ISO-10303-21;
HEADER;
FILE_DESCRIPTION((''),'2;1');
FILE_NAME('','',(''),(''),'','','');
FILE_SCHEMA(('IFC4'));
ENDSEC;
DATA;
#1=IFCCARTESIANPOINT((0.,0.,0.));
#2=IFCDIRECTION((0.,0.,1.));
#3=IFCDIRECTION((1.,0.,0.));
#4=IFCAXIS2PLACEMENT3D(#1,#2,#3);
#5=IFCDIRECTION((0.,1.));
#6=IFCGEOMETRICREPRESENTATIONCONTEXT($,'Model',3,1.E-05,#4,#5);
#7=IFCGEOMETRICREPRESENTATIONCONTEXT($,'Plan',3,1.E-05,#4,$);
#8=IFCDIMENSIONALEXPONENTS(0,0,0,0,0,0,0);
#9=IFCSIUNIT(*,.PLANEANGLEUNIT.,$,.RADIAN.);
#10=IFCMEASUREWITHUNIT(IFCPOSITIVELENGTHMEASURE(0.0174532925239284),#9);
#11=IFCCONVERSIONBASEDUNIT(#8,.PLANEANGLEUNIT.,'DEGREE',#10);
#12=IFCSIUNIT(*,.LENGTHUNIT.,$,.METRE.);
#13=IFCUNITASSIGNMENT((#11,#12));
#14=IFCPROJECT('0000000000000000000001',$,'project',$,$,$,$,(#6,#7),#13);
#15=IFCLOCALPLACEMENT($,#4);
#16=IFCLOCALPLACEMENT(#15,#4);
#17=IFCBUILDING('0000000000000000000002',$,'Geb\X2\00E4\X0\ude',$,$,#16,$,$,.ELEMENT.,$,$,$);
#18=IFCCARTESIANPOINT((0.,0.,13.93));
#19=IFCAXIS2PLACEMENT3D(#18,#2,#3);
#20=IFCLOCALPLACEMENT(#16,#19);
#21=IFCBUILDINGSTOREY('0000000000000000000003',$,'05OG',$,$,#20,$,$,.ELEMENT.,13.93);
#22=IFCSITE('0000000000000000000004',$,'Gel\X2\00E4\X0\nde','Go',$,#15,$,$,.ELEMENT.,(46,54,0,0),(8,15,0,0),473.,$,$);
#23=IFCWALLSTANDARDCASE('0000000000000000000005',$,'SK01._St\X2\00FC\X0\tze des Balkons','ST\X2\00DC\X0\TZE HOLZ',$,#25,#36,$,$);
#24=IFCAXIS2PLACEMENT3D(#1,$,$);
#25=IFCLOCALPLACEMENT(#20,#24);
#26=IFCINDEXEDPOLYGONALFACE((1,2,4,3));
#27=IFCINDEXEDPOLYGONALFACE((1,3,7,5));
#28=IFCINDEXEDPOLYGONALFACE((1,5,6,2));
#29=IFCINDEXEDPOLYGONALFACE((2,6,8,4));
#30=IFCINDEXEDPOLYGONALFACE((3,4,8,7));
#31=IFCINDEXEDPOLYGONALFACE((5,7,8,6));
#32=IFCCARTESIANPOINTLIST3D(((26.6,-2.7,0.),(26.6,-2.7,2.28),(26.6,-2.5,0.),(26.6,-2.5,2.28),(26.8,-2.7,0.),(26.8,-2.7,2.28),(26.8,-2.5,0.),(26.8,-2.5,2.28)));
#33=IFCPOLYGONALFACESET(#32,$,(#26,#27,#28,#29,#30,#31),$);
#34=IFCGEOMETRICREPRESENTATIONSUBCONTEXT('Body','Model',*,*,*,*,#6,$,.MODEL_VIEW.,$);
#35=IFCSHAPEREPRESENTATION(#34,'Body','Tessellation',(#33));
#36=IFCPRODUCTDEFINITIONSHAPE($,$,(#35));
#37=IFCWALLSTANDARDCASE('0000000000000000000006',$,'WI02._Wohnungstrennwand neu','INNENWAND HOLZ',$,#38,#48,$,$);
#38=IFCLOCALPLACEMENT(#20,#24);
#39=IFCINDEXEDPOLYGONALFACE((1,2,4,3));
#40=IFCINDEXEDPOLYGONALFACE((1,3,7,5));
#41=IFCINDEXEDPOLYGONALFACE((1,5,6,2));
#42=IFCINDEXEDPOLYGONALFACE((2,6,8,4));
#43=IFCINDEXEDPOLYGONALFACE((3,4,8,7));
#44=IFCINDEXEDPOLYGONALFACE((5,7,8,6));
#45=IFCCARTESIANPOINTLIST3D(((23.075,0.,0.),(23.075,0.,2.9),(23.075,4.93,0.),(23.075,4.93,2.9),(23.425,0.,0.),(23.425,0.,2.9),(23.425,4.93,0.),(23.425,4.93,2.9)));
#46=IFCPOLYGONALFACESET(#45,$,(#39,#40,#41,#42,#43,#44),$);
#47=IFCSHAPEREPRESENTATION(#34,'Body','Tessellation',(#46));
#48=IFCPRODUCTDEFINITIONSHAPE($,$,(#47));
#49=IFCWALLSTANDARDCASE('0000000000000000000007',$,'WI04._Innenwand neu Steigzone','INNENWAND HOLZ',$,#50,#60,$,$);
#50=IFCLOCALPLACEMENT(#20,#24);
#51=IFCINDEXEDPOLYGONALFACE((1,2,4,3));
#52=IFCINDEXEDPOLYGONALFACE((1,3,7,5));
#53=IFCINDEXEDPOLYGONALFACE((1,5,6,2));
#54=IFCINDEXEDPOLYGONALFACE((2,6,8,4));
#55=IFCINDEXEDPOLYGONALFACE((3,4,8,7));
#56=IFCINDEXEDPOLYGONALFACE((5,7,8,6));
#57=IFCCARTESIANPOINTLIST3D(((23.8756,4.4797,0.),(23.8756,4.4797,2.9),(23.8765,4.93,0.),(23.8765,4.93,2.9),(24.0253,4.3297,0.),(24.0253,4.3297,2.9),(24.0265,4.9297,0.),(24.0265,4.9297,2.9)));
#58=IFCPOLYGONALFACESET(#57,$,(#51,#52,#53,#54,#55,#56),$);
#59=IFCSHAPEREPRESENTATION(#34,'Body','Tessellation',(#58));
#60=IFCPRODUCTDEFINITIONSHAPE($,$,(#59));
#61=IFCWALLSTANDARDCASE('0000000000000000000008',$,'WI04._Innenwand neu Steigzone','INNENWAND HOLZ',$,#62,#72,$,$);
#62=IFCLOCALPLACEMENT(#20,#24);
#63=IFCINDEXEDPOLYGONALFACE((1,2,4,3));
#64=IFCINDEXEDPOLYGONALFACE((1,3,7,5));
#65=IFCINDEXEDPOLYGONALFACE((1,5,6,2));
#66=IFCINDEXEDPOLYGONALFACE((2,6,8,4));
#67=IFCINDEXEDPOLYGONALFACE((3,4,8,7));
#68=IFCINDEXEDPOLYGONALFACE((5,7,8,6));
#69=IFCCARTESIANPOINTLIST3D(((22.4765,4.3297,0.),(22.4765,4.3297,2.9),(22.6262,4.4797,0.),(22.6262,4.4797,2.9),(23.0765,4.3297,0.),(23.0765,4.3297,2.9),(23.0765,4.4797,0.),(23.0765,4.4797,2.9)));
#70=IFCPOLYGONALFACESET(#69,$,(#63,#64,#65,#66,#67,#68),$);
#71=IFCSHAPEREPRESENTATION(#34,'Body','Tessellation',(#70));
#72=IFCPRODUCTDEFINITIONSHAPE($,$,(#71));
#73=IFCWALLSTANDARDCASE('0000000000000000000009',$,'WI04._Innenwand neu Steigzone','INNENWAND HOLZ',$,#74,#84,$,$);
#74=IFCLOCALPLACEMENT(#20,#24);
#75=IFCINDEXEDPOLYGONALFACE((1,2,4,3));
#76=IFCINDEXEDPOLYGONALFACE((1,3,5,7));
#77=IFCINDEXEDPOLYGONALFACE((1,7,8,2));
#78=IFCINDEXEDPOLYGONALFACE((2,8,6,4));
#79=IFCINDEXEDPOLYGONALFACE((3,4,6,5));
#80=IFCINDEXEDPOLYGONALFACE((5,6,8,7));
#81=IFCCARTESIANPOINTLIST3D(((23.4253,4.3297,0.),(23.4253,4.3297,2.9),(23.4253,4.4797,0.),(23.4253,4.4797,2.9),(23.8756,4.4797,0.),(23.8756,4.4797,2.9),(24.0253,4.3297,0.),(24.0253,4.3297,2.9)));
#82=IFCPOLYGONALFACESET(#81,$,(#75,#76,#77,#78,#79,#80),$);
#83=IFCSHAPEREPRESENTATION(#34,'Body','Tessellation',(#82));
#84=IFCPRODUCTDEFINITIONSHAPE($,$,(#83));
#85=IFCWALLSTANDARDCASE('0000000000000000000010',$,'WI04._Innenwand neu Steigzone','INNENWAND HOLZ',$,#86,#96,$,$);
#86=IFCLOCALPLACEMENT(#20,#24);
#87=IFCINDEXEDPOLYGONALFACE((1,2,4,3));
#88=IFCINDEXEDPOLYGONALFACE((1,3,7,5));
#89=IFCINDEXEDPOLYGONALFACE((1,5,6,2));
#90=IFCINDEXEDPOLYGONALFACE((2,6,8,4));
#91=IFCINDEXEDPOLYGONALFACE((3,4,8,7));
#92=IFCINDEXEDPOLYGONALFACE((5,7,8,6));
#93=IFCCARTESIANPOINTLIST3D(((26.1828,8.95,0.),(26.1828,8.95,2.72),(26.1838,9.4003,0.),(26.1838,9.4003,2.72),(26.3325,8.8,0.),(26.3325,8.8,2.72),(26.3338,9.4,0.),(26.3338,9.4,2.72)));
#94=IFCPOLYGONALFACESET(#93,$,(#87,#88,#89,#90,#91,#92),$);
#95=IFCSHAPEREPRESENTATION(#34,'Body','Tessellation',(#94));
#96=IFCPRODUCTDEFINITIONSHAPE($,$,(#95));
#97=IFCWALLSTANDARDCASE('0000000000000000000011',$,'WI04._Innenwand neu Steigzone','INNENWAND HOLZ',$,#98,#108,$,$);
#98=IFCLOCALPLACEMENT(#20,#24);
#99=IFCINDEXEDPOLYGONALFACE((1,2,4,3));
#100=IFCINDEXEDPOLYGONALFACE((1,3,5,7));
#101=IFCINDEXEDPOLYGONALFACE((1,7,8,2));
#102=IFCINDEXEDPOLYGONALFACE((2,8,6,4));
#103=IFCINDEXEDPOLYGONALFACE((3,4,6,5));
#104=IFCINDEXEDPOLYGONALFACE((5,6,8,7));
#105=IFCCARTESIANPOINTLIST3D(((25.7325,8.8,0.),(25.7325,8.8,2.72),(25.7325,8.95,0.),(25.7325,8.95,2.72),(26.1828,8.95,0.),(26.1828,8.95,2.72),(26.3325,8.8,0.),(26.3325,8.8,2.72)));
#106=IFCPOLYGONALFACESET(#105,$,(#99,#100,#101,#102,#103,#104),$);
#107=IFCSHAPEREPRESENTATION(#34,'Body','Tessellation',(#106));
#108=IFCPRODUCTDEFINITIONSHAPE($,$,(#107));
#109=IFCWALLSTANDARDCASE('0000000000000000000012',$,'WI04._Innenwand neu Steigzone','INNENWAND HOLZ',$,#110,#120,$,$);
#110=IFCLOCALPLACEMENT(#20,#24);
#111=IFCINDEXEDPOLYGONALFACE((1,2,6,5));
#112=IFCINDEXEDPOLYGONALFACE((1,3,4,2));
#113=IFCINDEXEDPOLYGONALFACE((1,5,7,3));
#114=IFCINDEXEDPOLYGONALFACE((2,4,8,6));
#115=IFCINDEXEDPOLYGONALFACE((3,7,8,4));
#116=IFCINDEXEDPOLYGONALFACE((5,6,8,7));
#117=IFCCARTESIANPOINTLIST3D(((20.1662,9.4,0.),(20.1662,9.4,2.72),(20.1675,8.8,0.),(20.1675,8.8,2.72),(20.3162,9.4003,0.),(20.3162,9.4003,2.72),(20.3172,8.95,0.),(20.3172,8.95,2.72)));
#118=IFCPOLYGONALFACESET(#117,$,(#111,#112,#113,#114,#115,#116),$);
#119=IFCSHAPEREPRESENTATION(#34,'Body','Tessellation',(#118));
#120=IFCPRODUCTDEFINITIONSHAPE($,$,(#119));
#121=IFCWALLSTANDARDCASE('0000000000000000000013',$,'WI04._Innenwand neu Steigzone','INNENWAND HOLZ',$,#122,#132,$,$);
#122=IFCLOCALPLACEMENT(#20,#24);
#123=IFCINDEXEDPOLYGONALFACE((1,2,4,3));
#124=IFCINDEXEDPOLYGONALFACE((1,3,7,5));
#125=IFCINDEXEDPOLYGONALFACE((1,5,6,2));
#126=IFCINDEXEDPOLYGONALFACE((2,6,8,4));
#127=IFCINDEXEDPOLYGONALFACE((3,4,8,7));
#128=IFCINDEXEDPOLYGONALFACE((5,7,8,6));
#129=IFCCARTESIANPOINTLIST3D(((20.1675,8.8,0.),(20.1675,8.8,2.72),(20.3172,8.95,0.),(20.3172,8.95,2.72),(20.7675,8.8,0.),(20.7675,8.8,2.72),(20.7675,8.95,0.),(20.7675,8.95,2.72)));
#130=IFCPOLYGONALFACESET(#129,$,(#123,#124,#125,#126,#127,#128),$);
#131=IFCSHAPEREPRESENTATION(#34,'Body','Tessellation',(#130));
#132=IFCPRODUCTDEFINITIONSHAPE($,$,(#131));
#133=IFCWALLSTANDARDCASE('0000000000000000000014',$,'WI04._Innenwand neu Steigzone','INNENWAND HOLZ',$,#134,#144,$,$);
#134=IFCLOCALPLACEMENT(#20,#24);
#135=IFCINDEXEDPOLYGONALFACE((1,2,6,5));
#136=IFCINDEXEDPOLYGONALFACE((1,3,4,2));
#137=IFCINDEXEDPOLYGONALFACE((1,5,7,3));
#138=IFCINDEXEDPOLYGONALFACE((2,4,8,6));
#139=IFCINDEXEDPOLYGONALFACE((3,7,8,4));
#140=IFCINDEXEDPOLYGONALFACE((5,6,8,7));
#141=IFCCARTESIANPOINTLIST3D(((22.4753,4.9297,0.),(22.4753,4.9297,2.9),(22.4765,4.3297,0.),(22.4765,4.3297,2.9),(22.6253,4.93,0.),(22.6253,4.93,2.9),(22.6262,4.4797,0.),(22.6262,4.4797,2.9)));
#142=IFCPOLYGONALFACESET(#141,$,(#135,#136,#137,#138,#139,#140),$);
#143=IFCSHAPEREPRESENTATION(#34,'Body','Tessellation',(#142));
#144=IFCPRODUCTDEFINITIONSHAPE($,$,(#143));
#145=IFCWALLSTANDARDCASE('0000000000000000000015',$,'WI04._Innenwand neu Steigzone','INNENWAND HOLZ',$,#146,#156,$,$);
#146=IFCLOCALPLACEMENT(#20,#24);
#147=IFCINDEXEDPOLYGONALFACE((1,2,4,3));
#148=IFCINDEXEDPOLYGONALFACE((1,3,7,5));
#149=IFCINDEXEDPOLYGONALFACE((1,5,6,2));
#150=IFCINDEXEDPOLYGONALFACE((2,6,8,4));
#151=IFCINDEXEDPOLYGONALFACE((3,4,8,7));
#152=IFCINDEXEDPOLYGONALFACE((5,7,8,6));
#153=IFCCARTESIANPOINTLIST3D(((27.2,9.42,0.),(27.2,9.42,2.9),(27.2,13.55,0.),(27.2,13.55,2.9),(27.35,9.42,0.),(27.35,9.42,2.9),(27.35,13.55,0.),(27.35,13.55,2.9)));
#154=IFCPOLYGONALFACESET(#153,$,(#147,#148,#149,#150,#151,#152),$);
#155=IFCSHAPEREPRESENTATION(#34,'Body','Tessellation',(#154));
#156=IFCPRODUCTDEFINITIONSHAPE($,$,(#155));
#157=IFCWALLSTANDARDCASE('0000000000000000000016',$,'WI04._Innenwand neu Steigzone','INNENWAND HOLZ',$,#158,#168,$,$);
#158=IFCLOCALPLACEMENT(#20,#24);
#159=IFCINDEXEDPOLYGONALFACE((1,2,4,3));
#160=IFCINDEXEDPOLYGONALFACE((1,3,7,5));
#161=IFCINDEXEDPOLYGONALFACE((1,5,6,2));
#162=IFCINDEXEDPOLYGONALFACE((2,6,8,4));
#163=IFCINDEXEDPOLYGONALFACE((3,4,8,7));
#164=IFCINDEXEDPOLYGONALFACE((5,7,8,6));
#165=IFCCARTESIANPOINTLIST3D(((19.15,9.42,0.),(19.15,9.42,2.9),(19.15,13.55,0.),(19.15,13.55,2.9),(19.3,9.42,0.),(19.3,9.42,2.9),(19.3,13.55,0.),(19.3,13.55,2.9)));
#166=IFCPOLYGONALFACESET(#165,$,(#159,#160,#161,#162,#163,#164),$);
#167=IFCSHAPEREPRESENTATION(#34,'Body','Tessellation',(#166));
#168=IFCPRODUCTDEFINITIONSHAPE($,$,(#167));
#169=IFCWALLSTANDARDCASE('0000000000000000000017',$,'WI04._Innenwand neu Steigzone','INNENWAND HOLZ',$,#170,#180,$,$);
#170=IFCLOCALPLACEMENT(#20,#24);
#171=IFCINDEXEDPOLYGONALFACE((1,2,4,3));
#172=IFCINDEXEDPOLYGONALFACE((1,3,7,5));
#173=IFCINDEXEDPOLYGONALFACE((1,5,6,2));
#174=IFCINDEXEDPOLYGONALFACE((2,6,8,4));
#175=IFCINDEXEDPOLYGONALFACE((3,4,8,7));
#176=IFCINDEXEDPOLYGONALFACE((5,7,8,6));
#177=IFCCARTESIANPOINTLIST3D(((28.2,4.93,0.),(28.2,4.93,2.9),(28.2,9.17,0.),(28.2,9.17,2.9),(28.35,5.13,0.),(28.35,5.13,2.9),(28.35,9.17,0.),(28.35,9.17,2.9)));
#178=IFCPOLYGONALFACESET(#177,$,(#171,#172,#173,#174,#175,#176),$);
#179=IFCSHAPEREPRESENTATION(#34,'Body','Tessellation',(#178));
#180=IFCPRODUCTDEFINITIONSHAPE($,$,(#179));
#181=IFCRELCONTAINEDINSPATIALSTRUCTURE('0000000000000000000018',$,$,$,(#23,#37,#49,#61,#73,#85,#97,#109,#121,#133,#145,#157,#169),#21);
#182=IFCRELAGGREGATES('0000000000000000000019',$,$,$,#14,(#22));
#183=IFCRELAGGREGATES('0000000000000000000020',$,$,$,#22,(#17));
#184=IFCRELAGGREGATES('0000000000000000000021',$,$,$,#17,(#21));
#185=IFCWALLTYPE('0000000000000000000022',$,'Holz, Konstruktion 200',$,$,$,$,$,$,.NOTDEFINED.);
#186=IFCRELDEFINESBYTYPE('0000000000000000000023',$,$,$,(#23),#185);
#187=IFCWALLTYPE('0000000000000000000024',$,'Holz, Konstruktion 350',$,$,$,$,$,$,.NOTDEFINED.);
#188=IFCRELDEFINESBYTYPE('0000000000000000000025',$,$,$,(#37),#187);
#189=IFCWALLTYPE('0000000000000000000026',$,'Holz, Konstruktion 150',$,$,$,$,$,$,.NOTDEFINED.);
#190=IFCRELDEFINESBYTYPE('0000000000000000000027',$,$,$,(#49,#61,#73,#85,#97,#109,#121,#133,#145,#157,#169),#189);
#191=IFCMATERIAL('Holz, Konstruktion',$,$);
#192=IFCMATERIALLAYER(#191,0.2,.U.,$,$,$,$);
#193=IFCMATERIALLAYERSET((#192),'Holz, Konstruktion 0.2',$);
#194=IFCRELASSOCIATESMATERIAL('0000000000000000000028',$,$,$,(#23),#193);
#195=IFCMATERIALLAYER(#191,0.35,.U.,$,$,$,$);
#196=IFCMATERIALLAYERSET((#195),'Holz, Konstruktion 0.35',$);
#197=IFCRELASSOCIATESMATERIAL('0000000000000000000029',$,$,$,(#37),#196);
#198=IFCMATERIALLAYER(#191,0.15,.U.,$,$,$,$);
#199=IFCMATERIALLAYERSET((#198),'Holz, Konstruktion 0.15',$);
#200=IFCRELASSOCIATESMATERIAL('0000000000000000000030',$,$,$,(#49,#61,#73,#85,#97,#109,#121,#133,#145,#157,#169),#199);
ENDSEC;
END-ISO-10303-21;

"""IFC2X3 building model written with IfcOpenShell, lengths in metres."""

from ifc_helpers import new_model, entity, si_unit, converted_unit, direction, frame, origin_with_axes, place, context, subcontext, project, spatial, polyline, outline, extrude, material, layer, layer_set, layer_usage, type_object, element, save


model = new_model("IFC2X3")

# Units and contexts
model_context = context("Model", 3, precision=1e-05, world=origin_with_axes(), true_north=direction((0.0, 1.0)))
plan_context = context("Plan", 3, precision=1e-05, world=origin_with_axes())
body_context = subcontext(model_context, "Body", "Model", "MODEL_VIEW")
ifc_project = project(units=[converted_unit("PLANEANGLEUNIT", "DEGREE", entity("IfcPositiveLengthMeasure", 0.0174532925239284), si_unit("PLANEANGLEUNIT", "RADIAN"), dimensions=[0, 0, 0, 0, 0, 0, 0]), si_unit("LENGTHUNIT", "METRE")], contexts=[model_context, plan_context])

# Site, building, storey
site_placement = place(None, origin_with_axes())
site = spatial("IfcSite", under=ifc_project, at=site_placement, Name="Gelände", Description="Go", CompositionType="ELEMENT", RefLatitude=(46, 54, 0, 0), RefLongitude=(8, 15, 0, 0), RefElevation=473.0)
building_placement = place(site_placement, origin_with_axes())
building = spatial("IfcBuilding", under=site, at=building_placement, Name="Gebäude", CompositionType="ELEMENT")
storey_placement = place(building_placement, frame((0.0, 0.0, 13.93), z_axis=(0.0, 0.0, 1.0), x_axis=(1.0, 0.0, 0.0)))
storey = spatial("IfcBuildingStorey", under=building, at=storey_placement, Name="05OG", CompositionType="ELEMENT", Elevation=13.93)

# Shared definitions
ifc_material_1 = material(Name="Holz, Konstruktion")

# Walls
ifc_layer_1 = layer(ifc_material_1, 0.2, ventilated="UNKNOWN")
ifc_layer_set_1 = layer_set([ifc_layer_1], Name="Holz, Konstruktion 0.2")
wall_type_1 = type_object("IfcWallType", Name="Holz, Konstruktion 200", PredefinedType="NOTDEFINED")
ifc_layer_usage_1 = layer_usage(ifc_layer_set_1, "AXIS2", "NEGATIVE", 0.0)
wall_1_placement = place(storey_placement, frame((26.6, -2.7, 0.0), z_axis=(0.0, 0.0, 1.0), x_axis=(0.0, 1.0, 0.0)))
element("IfcWallStandardCase", 1, at=wall_1_placement, inside=storey, type_object=wall_type_1, material=ifc_layer_usage_1, Name="SK01._Stütze des Balkons", Description="STÜTZE HOLZ", context=body_context, shape_type="SweptSolid", body=[
    extrude(outline(polyline([(0.0, -0.2), (0.2, -0.2), (0.2, 0.0), (0.0, 0.0), (0.0, -0.2)])), origin_with_axes(), (0.0, 0.0, 1.0), 2.28),
])
ifc_layer_2 = layer(ifc_material_1, 0.35, ventilated="UNKNOWN")
ifc_layer_set_2 = layer_set([ifc_layer_2], Name="Holz, Konstruktion 0.35")
ifc_layer_usage_2 = layer_usage(ifc_layer_set_2, "AXIS2", "NEGATIVE", 0.0)
wall_type_2 = type_object("IfcWallType", Name="Holz, Konstruktion 350", PredefinedType="NOTDEFINED")
wall_2_placement = place(storey_placement, frame((23.425, 4.93, 0.0), z_axis=(0.0, 0.0, 1.0), x_axis=(0.0, -1.0, 0.0)))
element("IfcWallStandardCase", 2, at=wall_2_placement, inside=storey, type_object=wall_type_2, material=ifc_layer_usage_2, Name="WI02._Wohnungstrennwand neu", Description="INNENWAND HOLZ", context=body_context, shape_type="SweptSolid", body=[
    extrude(outline(polyline([(0.0, -0.35), (4.93, -0.35), (4.93, 0.0), (0.0, 0.0), (0.0, -0.35)])), origin_with_axes(), (0.0, 0.0, 1.0), 2.9),
])
ifc_layer_3 = layer(ifc_material_1, 0.15, ventilated="UNKNOWN")
ifc_layer_set_3 = layer_set([ifc_layer_3], Name="Holz, Konstruktion 0.15")
ifc_layer_usage_3 = layer_usage(ifc_layer_set_3, "AXIS2", "NEGATIVE", 0.0)
wall_type_3 = type_object("IfcWallType", Name="Holz, Konstruktion 150", PredefinedType="NOTDEFINED")
wall_3_placement = place(storey_placement, frame((24.0265, 4.9297, 0.0), z_axis=(0.0, 0.0, 1.0), x_axis=(-0.002118, -0.999998, 0.0)))
element("IfcWallStandardCase", 3, at=wall_3_placement, inside=storey, type_object=wall_type_3, material=ifc_layer_usage_3, Name="WI04._Innenwand neu Steigzone", Description="INNENWAND HOLZ", context=body_context, shape_type="SweptSolid", body=[
    extrude(outline(polyline([(0.0, -0.15), (0.4503, -0.15), (0.6, 0.0), (0.0, 0.0), (0.0, -0.15)])), origin_with_axes(), (0.0, 0.0, 1.0), 2.9),
])
ifc_layer_usage_4 = layer_usage(ifc_layer_set_3, "AXIS2", "NEGATIVE", 0.0)
wall_4_placement = place(storey_placement, frame((23.0765, 4.3297, 0.0), z_axis=(0.0, 0.0, 1.0), x_axis=(-1.0, 0.0, 0.0)))
element("IfcWallStandardCase", 4, at=wall_4_placement, inside=storey, type_object=wall_type_3, material=ifc_layer_usage_4, Name="WI04._Innenwand neu Steigzone", Description="INNENWAND HOLZ", context=body_context, shape_type="SweptSolid", body=[
    extrude(outline(polyline([(0.0, -0.15), (0.4503, -0.15), (0.6, 0.0), (0.0, 0.0), (0.0, -0.15)])), origin_with_axes(), (0.0, 0.0, 1.0), 2.9),
])
ifc_layer_usage_5 = layer_usage(ifc_layer_set_3, "AXIS2", "NEGATIVE", 0.0)
wall_5_placement = place(storey_placement, frame((24.0253, 4.3297, 0.0), z_axis=(0.0, 0.0, 1.0), x_axis=(-1.0, 0.0, 0.0)))
element("IfcWallStandardCase", 5, at=wall_5_placement, inside=storey, type_object=wall_type_3, material=ifc_layer_usage_5, Name="WI04._Innenwand neu Steigzone", Description="INNENWAND HOLZ", context=body_context, shape_type="SweptSolid", body=[
    extrude(outline(polyline([(0.1497, -0.15), (0.6, -0.15), (0.6, 0.0), (0.0, 0.0), (0.1497, -0.15)])), origin_with_axes(), (0.0, 0.0, 1.0), 2.9),
])
ifc_layer_usage_6 = layer_usage(ifc_layer_set_3, "AXIS2", "NEGATIVE", 0.0)
wall_6_placement = place(storey_placement, frame((26.3338, 9.4, 0.0), z_axis=(0.0, 0.0, 1.0), x_axis=(-0.002118, -0.999998, 0.0)))
element("IfcWallStandardCase", 6, at=wall_6_placement, inside=storey, type_object=wall_type_3, material=ifc_layer_usage_6, Name="WI04._Innenwand neu Steigzone", Description="INNENWAND HOLZ", context=body_context, shape_type="SweptSolid", body=[
    extrude(outline(polyline([(0.0, -0.15), (0.4503, -0.15), (0.6, 0.0), (0.0, 0.0), (0.0, -0.15)])), origin_with_axes(), (0.0, 0.0, 1.0), 2.72),
])
ifc_layer_usage_7 = layer_usage(ifc_layer_set_3, "AXIS2", "NEGATIVE", 0.0)
wall_7_placement = place(storey_placement, frame((26.3325, 8.8, 0.0), z_axis=(0.0, 0.0, 1.0), x_axis=(-1.0, 0.0, 0.0)))
element("IfcWallStandardCase", 7, at=wall_7_placement, inside=storey, type_object=wall_type_3, material=ifc_layer_usage_7, Name="WI04._Innenwand neu Steigzone", Description="INNENWAND HOLZ", context=body_context, shape_type="SweptSolid", body=[
    extrude(outline(polyline([(0.1497, -0.15), (0.6, -0.15), (0.6, 0.0), (0.0, 0.0), (0.1497, -0.15)])), origin_with_axes(), (0.0, 0.0, 1.0), 2.72),
])
ifc_layer_usage_8 = layer_usage(ifc_layer_set_3, "AXIS2", "POSITIVE", 0.0)
wall_8_placement = place(storey_placement, frame((20.1662, 9.4, 0.0), z_axis=(0.0, 0.0, 1.0), x_axis=(0.002118, -0.999998, 0.0)))
element("IfcWallStandardCase", 8, at=wall_8_placement, inside=storey, type_object=wall_type_3, material=ifc_layer_usage_8, Name="WI04._Innenwand neu Steigzone", Description="INNENWAND HOLZ", context=body_context, shape_type="SweptSolid", body=[
    extrude(outline(polyline([(0.0, 0.0), (0.6, 0.0), (0.4503, 0.15), (0.0, 0.15), (0.0, 0.0)])), origin_with_axes(), (0.0, 0.0, 1.0), 2.72),
])
ifc_layer_usage_9 = layer_usage(ifc_layer_set_3, "AXIS2", "POSITIVE", 0.0)
wall_9_placement = place(storey_placement, frame((20.1675, 8.8, 0.0), z_axis=(0.0, 0.0, 1.0), x_axis=(1.0, 0.0, 0.0)))
element("IfcWallStandardCase", 9, at=wall_9_placement, inside=storey, type_object=wall_type_3, material=ifc_layer_usage_9, Name="WI04._Innenwand neu Steigzone", Description="INNENWAND HOLZ", context=body_context, shape_type="SweptSolid", body=[
    extrude(outline(polyline([(0.0, 0.0), (0.6, 0.0), (0.6, 0.15), (0.1497, 0.15), (0.0, 0.0)])), origin_with_axes(), (0.0, 0.0, 1.0), 2.72),
])
ifc_layer_usage_10 = layer_usage(ifc_layer_set_3, "AXIS2", "NEGATIVE", 0.0)
wall_10_placement = place(storey_placement, frame((22.4765, 4.3297, 0.0), z_axis=(0.0, 0.0, 1.0), x_axis=(-0.002118, 0.999998, 0.0)))
element("IfcWallStandardCase", 10, at=wall_10_placement, inside=storey, type_object=wall_type_3, material=ifc_layer_usage_10, Name="WI04._Innenwand neu Steigzone", Description="INNENWAND HOLZ", context=body_context, shape_type="SweptSolid", body=[
    extrude(outline(polyline([(0.1497, -0.15), (0.6, -0.15), (0.6, 0.0), (0.0, 0.0), (0.1497, -0.15)])), origin_with_axes(), (0.0, 0.0, 1.0), 2.9),
])
ifc_layer_usage_11 = layer_usage(ifc_layer_set_3, "AXIS2", "POSITIVE", 0.0)
wall_11_placement = place(storey_placement, frame((27.2, 13.55, 0.0), z_axis=(0.0, 0.0, 1.0), x_axis=(0.0, -1.0, 0.0)))
element("IfcWallStandardCase", 11, at=wall_11_placement, inside=storey, type_object=wall_type_3, material=ifc_layer_usage_11, Name="WI04._Innenwand neu Steigzone", Description="INNENWAND HOLZ", context=body_context, shape_type="SweptSolid", body=[
    extrude(outline(polyline([(0.0, 0.0), (4.13, 0.0), (4.13, 0.15), (0.0, 0.15), (0.0, 0.0)])), origin_with_axes(), (0.0, 0.0, 1.0), 2.9),
])
ifc_layer_usage_12 = layer_usage(ifc_layer_set_3, "AXIS2", "POSITIVE", 0.0)
wall_12_placement = place(storey_placement, frame((19.15, 13.55, 0.0), z_axis=(0.0, 0.0, 1.0), x_axis=(0.0, -1.0, 0.0)))
element("IfcWallStandardCase", 12, at=wall_12_placement, inside=storey, type_object=wall_type_3, material=ifc_layer_usage_12, Name="WI04._Innenwand neu Steigzone", Description="INNENWAND HOLZ", context=body_context, shape_type="SweptSolid", body=[
    extrude(outline(polyline([(0.0, 0.0), (4.13, 0.0), (4.13, 0.15), (0.0, 0.15), (0.0, 0.0)])), origin_with_axes(), (0.0, 0.0, 1.0), 2.9),
])
ifc_layer_usage_13 = layer_usage(ifc_layer_set_3, "AXIS2", "POSITIVE", 0.0)
wall_13_placement = place(storey_placement, frame((28.2, 9.17, 0.0), z_axis=(0.0, 0.0, 1.0), x_axis=(0.0, -1.0, 0.0)))
element("IfcWallStandardCase", 13, at=wall_13_placement, inside=storey, type_object=wall_type_3, material=ifc_layer_usage_13, Name="WI04._Innenwand neu Steigzone", Description="INNENWAND HOLZ", context=body_context, shape_type="SweptSolid", body=[
    extrude(outline(polyline([(0.0, 0.0), (4.24, 0.0), (4.04, 0.15), (0.0, 0.15), (0.0, 0.0)])), origin_with_axes(), (0.0, 0.0, 1.0), 2.9),
])

save(model, "model.ifc")
